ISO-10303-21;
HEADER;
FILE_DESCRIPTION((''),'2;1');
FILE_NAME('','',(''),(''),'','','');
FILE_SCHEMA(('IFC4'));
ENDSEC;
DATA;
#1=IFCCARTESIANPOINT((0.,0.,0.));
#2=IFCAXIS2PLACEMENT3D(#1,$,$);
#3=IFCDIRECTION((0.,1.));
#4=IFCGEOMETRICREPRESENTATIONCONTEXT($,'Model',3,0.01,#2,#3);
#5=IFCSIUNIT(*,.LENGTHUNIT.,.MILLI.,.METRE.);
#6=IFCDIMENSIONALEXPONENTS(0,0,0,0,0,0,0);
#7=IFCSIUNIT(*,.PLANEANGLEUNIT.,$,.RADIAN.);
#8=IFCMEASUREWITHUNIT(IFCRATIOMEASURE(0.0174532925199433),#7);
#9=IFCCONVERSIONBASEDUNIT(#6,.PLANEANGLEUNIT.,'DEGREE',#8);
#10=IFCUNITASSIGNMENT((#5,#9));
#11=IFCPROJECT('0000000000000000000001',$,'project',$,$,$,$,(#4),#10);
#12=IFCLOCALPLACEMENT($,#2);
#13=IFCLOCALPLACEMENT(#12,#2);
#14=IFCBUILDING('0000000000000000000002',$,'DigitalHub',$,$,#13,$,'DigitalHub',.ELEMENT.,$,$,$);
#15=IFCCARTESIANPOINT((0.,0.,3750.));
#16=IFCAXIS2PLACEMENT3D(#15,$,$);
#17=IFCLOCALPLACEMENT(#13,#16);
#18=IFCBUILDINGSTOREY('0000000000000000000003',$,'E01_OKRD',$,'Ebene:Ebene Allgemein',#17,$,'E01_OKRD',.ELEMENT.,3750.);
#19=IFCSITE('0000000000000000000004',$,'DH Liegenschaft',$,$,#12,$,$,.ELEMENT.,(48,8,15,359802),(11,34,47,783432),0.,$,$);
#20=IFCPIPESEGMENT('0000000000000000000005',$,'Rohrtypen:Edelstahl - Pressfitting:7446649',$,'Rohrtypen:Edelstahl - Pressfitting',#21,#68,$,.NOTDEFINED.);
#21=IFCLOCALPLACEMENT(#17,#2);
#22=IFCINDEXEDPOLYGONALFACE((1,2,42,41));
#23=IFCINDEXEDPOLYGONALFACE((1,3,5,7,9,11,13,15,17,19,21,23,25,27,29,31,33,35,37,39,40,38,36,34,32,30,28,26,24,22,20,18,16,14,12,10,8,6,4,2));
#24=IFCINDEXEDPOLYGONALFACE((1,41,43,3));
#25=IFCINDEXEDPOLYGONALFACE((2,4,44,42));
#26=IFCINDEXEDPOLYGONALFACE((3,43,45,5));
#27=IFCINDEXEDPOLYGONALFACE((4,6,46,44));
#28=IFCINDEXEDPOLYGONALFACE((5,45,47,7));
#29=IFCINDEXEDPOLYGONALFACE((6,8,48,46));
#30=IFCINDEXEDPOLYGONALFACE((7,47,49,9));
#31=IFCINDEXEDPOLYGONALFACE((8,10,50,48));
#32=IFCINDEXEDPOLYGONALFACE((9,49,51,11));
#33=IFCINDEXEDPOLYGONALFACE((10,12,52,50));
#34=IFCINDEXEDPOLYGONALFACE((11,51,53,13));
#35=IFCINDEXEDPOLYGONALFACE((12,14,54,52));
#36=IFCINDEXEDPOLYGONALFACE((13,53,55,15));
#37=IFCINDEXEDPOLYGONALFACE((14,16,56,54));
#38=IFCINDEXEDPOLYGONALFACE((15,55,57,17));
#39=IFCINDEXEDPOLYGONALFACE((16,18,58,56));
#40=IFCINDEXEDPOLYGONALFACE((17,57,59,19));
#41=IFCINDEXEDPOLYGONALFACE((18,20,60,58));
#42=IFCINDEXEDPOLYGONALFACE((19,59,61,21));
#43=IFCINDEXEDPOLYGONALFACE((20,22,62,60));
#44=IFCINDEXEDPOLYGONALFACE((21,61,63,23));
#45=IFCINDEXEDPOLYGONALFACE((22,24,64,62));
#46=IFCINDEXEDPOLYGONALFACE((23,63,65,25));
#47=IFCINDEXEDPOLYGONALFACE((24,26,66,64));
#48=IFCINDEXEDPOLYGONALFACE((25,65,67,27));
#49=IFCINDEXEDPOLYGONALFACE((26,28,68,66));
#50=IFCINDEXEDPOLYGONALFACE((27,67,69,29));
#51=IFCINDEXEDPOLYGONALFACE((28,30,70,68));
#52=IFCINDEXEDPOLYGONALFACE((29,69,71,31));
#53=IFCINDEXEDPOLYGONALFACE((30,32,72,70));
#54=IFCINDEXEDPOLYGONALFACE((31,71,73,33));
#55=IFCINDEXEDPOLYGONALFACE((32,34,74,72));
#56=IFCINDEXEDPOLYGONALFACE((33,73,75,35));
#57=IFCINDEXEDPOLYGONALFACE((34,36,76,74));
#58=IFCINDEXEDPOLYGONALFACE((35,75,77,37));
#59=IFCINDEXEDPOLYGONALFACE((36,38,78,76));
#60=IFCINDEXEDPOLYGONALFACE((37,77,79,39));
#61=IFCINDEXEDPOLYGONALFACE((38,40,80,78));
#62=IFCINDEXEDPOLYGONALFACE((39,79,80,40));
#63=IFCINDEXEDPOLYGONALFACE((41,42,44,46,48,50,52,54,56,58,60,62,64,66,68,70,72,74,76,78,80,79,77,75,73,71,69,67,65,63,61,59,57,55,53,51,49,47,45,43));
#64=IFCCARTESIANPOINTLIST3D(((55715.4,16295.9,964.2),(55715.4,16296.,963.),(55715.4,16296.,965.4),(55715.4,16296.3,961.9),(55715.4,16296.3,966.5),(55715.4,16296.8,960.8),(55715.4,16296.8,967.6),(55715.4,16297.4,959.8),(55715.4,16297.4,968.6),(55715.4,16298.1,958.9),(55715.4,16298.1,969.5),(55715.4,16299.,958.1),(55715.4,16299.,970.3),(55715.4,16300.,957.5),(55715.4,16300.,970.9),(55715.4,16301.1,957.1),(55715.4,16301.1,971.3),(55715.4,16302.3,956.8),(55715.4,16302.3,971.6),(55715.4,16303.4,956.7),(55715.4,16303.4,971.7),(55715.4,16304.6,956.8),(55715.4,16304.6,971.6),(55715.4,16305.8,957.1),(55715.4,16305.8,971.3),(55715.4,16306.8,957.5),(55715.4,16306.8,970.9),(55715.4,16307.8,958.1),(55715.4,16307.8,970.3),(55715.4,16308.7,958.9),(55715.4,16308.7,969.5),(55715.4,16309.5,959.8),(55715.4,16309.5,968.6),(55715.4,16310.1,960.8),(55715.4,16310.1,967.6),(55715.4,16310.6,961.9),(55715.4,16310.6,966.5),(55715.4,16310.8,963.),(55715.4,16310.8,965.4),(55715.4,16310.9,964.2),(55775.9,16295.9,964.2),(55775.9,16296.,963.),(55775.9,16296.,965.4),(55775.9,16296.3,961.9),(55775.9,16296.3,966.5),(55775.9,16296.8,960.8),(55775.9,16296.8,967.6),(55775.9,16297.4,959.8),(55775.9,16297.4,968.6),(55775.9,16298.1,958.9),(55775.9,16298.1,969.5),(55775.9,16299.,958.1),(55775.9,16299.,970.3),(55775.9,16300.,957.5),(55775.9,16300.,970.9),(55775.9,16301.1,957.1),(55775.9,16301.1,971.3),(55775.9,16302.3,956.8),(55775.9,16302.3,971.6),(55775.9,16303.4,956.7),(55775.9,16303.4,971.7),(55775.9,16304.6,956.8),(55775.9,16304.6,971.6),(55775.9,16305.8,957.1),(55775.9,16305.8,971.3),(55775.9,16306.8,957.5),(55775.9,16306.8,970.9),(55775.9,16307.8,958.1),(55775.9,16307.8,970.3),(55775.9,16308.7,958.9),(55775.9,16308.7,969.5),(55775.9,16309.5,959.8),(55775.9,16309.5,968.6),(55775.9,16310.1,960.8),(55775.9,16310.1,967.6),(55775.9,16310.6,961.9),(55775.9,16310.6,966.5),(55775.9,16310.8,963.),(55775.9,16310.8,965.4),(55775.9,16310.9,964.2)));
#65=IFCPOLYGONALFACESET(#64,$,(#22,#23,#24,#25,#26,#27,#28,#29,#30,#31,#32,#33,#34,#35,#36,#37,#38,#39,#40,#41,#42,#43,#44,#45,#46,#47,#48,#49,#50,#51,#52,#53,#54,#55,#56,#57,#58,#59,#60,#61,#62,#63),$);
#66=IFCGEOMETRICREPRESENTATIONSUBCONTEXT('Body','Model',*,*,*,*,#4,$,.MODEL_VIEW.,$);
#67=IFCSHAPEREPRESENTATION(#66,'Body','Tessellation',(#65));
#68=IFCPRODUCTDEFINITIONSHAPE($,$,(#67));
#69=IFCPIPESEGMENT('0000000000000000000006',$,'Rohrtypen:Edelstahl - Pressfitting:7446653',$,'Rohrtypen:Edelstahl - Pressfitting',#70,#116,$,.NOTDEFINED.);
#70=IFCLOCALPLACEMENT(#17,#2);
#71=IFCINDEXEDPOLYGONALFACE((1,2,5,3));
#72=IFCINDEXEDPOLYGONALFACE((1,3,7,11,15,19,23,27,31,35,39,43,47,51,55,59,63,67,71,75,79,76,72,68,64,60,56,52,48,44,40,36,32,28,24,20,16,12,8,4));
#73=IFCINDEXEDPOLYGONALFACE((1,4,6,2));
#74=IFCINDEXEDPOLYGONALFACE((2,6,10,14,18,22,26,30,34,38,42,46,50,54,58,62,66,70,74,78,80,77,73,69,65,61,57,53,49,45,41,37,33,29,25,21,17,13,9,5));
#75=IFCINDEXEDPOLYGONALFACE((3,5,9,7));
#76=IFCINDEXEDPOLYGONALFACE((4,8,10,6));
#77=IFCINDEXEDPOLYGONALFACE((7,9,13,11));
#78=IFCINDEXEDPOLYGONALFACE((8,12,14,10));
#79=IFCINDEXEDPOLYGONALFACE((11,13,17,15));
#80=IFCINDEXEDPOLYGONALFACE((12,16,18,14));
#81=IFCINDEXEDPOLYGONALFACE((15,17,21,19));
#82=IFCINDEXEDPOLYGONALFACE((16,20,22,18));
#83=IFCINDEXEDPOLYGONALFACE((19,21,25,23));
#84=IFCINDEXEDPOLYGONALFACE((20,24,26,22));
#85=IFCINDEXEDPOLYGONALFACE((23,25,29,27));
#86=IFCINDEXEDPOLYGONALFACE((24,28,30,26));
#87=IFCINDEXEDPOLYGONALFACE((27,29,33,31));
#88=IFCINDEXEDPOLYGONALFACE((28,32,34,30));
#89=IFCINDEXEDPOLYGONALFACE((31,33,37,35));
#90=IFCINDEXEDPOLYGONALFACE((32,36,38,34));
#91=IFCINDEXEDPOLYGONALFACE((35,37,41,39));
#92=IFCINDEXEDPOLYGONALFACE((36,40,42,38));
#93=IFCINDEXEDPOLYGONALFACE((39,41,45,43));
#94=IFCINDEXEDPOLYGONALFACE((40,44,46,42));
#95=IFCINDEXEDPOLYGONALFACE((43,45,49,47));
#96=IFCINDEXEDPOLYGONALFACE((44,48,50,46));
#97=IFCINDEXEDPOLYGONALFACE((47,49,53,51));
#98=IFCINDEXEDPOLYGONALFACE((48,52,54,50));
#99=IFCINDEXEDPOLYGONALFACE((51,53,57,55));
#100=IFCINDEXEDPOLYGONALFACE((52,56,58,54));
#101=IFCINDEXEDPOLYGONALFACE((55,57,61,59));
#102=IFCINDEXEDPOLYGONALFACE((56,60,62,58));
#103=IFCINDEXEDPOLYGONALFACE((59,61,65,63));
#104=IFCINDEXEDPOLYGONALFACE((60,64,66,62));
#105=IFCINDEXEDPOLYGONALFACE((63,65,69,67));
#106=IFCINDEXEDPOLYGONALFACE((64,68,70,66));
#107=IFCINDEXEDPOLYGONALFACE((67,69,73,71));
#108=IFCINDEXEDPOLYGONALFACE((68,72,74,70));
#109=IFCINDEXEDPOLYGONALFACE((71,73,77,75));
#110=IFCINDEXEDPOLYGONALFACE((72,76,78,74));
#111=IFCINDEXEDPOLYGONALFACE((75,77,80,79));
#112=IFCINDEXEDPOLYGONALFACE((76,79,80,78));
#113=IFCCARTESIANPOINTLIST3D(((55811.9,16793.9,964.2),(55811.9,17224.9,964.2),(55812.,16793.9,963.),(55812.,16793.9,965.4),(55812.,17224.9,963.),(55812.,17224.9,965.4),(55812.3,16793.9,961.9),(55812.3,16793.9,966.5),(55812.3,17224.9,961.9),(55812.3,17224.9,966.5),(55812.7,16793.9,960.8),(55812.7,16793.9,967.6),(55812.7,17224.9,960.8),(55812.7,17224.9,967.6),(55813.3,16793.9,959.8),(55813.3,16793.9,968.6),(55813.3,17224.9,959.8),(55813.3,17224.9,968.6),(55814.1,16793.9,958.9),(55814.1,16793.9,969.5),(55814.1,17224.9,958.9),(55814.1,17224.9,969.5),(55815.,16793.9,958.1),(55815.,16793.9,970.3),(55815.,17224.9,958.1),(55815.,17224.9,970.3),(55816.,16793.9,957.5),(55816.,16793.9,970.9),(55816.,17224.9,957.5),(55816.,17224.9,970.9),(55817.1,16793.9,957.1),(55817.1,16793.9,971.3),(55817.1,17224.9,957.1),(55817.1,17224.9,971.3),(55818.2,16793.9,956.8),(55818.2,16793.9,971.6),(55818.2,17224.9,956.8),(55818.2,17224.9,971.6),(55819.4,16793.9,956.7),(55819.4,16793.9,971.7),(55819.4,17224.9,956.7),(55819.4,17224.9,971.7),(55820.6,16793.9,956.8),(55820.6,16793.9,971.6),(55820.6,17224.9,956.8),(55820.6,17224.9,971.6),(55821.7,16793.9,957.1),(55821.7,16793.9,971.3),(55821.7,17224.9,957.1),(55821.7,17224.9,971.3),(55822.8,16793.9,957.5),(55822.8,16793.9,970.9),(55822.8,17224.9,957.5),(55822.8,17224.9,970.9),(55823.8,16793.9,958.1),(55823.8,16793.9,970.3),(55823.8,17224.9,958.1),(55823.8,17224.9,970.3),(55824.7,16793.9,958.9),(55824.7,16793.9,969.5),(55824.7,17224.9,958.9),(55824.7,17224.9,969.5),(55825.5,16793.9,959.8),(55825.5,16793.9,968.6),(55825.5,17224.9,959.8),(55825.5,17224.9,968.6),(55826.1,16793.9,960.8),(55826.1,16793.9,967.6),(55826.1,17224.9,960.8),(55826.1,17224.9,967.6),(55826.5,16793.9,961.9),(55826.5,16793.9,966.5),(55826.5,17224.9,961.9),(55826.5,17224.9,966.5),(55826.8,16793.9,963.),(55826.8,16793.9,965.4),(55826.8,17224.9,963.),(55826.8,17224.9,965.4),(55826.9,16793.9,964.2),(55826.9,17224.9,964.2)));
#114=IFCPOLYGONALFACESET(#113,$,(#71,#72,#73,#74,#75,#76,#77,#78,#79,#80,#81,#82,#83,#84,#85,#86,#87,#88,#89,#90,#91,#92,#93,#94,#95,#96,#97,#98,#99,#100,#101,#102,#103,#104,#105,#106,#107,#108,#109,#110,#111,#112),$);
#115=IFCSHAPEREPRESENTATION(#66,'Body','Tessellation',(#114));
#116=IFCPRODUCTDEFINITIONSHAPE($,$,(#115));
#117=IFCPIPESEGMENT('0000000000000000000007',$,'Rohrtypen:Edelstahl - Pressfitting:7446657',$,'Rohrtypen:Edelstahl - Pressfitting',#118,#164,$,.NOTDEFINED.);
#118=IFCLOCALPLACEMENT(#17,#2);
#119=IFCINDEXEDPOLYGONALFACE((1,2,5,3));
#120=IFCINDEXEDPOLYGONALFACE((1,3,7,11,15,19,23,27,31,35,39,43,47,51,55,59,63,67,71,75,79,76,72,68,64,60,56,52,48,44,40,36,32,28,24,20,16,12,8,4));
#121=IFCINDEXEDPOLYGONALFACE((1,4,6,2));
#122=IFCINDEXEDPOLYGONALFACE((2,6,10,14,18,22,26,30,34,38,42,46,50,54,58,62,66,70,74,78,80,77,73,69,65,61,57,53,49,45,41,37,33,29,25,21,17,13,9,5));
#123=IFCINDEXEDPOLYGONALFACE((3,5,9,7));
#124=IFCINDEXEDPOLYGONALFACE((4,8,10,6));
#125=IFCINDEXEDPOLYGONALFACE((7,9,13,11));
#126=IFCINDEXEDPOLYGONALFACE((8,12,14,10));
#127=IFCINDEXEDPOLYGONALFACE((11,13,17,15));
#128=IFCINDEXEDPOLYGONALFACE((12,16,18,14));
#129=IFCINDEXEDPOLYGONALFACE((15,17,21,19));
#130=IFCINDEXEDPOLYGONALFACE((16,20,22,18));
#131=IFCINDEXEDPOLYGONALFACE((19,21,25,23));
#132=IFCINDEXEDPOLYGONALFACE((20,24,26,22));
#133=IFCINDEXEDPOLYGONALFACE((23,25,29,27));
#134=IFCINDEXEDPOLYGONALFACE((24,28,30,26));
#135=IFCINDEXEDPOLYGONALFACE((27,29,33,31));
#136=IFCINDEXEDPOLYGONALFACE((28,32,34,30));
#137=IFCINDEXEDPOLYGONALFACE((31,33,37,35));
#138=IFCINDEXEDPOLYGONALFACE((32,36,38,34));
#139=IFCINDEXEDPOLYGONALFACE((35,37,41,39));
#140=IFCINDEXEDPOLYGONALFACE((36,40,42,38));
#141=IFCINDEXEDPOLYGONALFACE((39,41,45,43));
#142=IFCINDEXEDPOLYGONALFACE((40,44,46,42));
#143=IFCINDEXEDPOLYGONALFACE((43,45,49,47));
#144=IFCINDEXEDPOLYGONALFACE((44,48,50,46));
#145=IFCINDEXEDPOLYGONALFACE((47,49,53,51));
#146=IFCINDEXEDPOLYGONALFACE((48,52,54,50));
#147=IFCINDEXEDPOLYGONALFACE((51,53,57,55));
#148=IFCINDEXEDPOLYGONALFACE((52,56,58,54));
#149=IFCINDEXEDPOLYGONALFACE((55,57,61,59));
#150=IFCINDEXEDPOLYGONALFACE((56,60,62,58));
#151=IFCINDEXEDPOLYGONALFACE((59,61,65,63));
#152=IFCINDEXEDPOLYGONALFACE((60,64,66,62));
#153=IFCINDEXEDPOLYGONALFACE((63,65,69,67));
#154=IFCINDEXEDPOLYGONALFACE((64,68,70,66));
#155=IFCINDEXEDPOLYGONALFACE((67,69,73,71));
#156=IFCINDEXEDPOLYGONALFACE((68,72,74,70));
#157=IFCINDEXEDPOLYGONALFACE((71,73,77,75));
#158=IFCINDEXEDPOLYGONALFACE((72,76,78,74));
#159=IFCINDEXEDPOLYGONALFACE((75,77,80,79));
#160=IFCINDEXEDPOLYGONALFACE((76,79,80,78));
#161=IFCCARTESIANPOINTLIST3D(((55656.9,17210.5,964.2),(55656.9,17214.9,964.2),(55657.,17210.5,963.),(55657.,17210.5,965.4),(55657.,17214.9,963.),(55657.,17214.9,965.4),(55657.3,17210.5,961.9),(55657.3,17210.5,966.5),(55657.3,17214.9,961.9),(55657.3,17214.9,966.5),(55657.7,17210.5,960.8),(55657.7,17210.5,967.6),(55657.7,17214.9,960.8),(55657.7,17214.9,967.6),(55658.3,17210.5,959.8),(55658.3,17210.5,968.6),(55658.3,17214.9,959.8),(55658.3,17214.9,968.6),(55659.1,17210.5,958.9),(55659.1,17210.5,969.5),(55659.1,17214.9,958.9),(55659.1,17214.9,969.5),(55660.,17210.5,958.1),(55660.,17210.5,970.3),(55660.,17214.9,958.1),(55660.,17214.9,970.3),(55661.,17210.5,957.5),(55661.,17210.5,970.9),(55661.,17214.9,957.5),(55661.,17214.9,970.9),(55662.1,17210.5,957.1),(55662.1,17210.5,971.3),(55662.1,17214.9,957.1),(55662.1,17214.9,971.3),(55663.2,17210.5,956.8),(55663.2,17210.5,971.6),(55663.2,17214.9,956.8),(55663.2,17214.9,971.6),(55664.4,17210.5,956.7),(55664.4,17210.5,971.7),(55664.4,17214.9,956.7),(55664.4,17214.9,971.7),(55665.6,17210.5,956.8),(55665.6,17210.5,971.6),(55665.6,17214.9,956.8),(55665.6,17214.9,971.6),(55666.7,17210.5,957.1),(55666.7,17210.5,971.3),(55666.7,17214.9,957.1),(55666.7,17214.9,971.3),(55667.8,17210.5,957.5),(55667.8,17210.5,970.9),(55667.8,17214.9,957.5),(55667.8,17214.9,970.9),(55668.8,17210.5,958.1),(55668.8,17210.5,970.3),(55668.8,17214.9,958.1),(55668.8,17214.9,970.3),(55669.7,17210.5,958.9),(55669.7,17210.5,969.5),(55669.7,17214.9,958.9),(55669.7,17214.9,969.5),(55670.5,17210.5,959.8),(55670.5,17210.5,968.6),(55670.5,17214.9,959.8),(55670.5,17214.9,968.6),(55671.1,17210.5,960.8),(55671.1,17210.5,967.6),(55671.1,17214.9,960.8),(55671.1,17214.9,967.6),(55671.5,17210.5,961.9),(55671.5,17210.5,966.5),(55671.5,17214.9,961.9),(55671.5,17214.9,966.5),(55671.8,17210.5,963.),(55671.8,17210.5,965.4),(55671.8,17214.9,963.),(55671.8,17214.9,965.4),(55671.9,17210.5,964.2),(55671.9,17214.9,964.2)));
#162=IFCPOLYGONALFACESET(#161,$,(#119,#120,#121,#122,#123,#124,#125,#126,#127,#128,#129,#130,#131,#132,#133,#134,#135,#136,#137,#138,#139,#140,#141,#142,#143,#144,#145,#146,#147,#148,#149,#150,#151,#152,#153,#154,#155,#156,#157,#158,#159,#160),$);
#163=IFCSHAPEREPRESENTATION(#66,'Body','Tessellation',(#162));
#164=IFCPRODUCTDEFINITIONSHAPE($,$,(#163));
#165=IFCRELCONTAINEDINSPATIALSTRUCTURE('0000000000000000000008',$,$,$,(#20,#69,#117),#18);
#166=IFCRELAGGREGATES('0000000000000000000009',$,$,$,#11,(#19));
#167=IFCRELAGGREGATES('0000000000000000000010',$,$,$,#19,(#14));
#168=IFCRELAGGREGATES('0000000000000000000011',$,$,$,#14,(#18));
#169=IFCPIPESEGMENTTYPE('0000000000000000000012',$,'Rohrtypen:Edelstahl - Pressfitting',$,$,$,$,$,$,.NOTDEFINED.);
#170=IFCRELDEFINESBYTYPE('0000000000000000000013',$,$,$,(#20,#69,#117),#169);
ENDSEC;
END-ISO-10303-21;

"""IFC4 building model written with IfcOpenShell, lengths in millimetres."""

from ifc_helpers import new_model, entity, si_unit, converted_unit, direction, frame, origin, place, context, subcontext, project, spatial, indexed_curve, outline, extrude, type_object, element, save


model = new_model("IFC4")

# Units and contexts
model_context = context("Model", 3, precision=0.01, world=origin(), true_north=direction((0.0, 1.0)))
body_context = subcontext(model_context, "Body", "Model", "MODEL_VIEW")
ifc_project = project(units=[si_unit("LENGTHUNIT", "METRE", prefix="MILLI"), converted_unit("PLANEANGLEUNIT", "DEGREE", entity("IfcRatioMeasure", 0.0174532925199433), si_unit("PLANEANGLEUNIT", "RADIAN"), dimensions=[0, 0, 0, 0, 0, 0, 0])], contexts=[model_context])

# Site, building, storey
site_placement = place(None, origin())
site = spatial("IfcSite", under=ifc_project, at=site_placement, Name="DH Liegenschaft", CompositionType="ELEMENT", RefLatitude=(48, 8, 15, 359802), RefLongitude=(11, 34, 47, 783432), RefElevation=0.0)
building_placement = place(site_placement, origin())
building = spatial("IfcBuilding", under=site, at=building_placement, Name="DigitalHub", LongName="DigitalHub", CompositionType="ELEMENT")
storey_placement = place(building_placement, frame((0.0, 0.0, 3750.0)))
storey = spatial("IfcBuildingStorey", under=building, at=storey_placement, Name="E01_OKRD", ObjectType="Ebene:Ebene Allgemein", LongName="E01_OKRD", CompositionType="ELEMENT", Elevation=3750.0)

# Pipe segments
pipe_segment_type_1 = type_object("IfcPipeSegmentType", Name="Rohrtypen:Edelstahl - Pressfitting", PredefinedType="NOTDEFINED")
pipe_segment_1_placement = place(storey_placement, frame((55715.4, 16294.3, 955.1)))
element("IfcPipeSegment", 1, at=pipe_segment_1_placement, inside=storey, type_object=pipe_segment_type_1, Name="Rohrtypen:Edelstahl - Pressfitting:7446649", ObjectType="Rohrtypen:Edelstahl - Pressfitting", PredefinedType="NOTDEFINED", context=body_context, shape_type="SweptSolid", body=[
    extrude(outline(indexed_curve([(7.5, 0.0), (7.4, 1.2), (7.1, 2.3), (6.7, 3.4), (6.1, 4.4), (5.3, 5.3), (4.4, 6.1), (3.4, 6.7), (2.3, 7.1), (1.2, 7.4), (0.0, 7.5), (-1.2, 7.4), (-2.3, 7.1), (-3.4, 6.7), (-4.4, 6.1), (-5.3, 5.3), (-6.1, 4.4), (-6.7, 3.4), (-7.1, 2.3), (-7.4, 1.2), (-7.5, 0.0), (-7.4, -1.2), (-7.1, -2.3), (-6.7, -3.4), (-6.1, -4.4), (-5.3, -5.3), (-4.4, -6.1), (-3.4, -6.7), (-2.3, -7.1), (-1.2, -7.4), (0.0, -7.5), (1.2, -7.4), (2.3, -7.1), (3.4, -6.7), (4.4, -6.1), (5.3, -5.3), (6.1, -4.4), (6.7, -3.4), (7.1, -2.3), (7.4, -1.2), (7.5, 0.0)], self_intersect=False)), frame((60.5, 9.1, 9.1), z_axis=(-1.0, 0.0, 0.000221), x_axis=(0.0, -1.0, 0.0)), (0.0, 0.0, 1.0), 60.5),
])
pipe_segment_2_placement = place(storey_placement, frame((55810.3, 16793.9, 955.1)))
element("IfcPipeSegment", 2, at=pipe_segment_2_placement, inside=storey, type_object=pipe_segment_type_1, Name="Rohrtypen:Edelstahl - Pressfitting:7446653", ObjectType="Rohrtypen:Edelstahl - Pressfitting", PredefinedType="NOTDEFINED", context=body_context, shape_type="SweptSolid", body=[
    extrude(outline(indexed_curve([(7.5, 0.0), (7.4, 1.2), (7.1, 2.3), (6.7, 3.4), (6.1, 4.4), (5.3, 5.3), (4.4, 6.1), (3.4, 6.7), (2.3, 7.1), (1.2, 7.4), (0.0, 7.5), (-1.2, 7.4), (-2.3, 7.1), (-3.4, 6.7), (-4.4, 6.1), (-5.3, 5.3), (-6.1, 4.4), (-6.7, 3.4), (-7.1, 2.3), (-7.4, 1.2), (-7.5, 0.0), (-7.4, -1.2), (-7.1, -2.3), (-6.7, -3.4), (-6.1, -4.4), (-5.3, -5.3), (-4.4, -6.1), (-3.4, -6.7), (-2.3, -7.1), (-1.2, -7.4), (0.0, -7.5), (1.2, -7.4), (2.3, -7.1), (3.4, -6.7), (4.4, -6.1), (5.3, -5.3), (6.1, -4.4), (6.7, -3.4), (7.1, -2.3), (7.4, -1.2), (7.5, 0.0)], self_intersect=False)), frame((9.1, 0.0, 9.1), z_axis=(0.0, 1.0, 0.0), x_axis=(1.0, 0.0, 0.0)), (0.0, 0.0, 1.0), 431.1),
])
pipe_segment_3_placement = place(storey_placement, frame((55655.3, 17210.5, 955.1)))
element("IfcPipeSegment", 3, at=pipe_segment_3_placement, inside=storey, type_object=pipe_segment_type_1, Name="Rohrtypen:Edelstahl - Pressfitting:7446657", ObjectType="Rohrtypen:Edelstahl - Pressfitting", PredefinedType="NOTDEFINED", context=body_context, shape_type="SweptSolid", body=[
    extrude(outline(indexed_curve([(7.5, 0.0), (7.4, 1.2), (7.1, 2.3), (6.7, 3.4), (6.1, 4.4), (5.3, 5.3), (4.4, 6.1), (3.4, 6.7), (2.3, 7.1), (1.2, 7.4), (0.0, 7.5), (-1.2, 7.4), (-2.3, 7.1), (-3.4, 6.7), (-4.4, 6.1), (-5.3, 5.3), (-6.1, 4.4), (-6.7, 3.4), (-7.1, 2.3), (-7.4, 1.2), (-7.5, 0.0), (-7.4, -1.2), (-7.1, -2.3), (-6.7, -3.4), (-6.1, -4.4), (-5.3, -5.3), (-4.4, -6.1), (-3.4, -6.7), (-2.3, -7.1), (-1.2, -7.4), (0.0, -7.5), (1.2, -7.4), (2.3, -7.1), (3.4, -6.7), (4.4, -6.1), (5.3, -5.3), (6.1, -4.4), (6.7, -3.4), (7.1, -2.3), (7.4, -1.2), (7.5, 0.0)], self_intersect=False)), frame((9.1, 0.0, 9.1), z_axis=(0.0, 1.0, 0.0), x_axis=(1.0, 0.0, 0.0)), (0.0, 0.0, 1.0), 4.4),
])

save(model, "model.ifc")
